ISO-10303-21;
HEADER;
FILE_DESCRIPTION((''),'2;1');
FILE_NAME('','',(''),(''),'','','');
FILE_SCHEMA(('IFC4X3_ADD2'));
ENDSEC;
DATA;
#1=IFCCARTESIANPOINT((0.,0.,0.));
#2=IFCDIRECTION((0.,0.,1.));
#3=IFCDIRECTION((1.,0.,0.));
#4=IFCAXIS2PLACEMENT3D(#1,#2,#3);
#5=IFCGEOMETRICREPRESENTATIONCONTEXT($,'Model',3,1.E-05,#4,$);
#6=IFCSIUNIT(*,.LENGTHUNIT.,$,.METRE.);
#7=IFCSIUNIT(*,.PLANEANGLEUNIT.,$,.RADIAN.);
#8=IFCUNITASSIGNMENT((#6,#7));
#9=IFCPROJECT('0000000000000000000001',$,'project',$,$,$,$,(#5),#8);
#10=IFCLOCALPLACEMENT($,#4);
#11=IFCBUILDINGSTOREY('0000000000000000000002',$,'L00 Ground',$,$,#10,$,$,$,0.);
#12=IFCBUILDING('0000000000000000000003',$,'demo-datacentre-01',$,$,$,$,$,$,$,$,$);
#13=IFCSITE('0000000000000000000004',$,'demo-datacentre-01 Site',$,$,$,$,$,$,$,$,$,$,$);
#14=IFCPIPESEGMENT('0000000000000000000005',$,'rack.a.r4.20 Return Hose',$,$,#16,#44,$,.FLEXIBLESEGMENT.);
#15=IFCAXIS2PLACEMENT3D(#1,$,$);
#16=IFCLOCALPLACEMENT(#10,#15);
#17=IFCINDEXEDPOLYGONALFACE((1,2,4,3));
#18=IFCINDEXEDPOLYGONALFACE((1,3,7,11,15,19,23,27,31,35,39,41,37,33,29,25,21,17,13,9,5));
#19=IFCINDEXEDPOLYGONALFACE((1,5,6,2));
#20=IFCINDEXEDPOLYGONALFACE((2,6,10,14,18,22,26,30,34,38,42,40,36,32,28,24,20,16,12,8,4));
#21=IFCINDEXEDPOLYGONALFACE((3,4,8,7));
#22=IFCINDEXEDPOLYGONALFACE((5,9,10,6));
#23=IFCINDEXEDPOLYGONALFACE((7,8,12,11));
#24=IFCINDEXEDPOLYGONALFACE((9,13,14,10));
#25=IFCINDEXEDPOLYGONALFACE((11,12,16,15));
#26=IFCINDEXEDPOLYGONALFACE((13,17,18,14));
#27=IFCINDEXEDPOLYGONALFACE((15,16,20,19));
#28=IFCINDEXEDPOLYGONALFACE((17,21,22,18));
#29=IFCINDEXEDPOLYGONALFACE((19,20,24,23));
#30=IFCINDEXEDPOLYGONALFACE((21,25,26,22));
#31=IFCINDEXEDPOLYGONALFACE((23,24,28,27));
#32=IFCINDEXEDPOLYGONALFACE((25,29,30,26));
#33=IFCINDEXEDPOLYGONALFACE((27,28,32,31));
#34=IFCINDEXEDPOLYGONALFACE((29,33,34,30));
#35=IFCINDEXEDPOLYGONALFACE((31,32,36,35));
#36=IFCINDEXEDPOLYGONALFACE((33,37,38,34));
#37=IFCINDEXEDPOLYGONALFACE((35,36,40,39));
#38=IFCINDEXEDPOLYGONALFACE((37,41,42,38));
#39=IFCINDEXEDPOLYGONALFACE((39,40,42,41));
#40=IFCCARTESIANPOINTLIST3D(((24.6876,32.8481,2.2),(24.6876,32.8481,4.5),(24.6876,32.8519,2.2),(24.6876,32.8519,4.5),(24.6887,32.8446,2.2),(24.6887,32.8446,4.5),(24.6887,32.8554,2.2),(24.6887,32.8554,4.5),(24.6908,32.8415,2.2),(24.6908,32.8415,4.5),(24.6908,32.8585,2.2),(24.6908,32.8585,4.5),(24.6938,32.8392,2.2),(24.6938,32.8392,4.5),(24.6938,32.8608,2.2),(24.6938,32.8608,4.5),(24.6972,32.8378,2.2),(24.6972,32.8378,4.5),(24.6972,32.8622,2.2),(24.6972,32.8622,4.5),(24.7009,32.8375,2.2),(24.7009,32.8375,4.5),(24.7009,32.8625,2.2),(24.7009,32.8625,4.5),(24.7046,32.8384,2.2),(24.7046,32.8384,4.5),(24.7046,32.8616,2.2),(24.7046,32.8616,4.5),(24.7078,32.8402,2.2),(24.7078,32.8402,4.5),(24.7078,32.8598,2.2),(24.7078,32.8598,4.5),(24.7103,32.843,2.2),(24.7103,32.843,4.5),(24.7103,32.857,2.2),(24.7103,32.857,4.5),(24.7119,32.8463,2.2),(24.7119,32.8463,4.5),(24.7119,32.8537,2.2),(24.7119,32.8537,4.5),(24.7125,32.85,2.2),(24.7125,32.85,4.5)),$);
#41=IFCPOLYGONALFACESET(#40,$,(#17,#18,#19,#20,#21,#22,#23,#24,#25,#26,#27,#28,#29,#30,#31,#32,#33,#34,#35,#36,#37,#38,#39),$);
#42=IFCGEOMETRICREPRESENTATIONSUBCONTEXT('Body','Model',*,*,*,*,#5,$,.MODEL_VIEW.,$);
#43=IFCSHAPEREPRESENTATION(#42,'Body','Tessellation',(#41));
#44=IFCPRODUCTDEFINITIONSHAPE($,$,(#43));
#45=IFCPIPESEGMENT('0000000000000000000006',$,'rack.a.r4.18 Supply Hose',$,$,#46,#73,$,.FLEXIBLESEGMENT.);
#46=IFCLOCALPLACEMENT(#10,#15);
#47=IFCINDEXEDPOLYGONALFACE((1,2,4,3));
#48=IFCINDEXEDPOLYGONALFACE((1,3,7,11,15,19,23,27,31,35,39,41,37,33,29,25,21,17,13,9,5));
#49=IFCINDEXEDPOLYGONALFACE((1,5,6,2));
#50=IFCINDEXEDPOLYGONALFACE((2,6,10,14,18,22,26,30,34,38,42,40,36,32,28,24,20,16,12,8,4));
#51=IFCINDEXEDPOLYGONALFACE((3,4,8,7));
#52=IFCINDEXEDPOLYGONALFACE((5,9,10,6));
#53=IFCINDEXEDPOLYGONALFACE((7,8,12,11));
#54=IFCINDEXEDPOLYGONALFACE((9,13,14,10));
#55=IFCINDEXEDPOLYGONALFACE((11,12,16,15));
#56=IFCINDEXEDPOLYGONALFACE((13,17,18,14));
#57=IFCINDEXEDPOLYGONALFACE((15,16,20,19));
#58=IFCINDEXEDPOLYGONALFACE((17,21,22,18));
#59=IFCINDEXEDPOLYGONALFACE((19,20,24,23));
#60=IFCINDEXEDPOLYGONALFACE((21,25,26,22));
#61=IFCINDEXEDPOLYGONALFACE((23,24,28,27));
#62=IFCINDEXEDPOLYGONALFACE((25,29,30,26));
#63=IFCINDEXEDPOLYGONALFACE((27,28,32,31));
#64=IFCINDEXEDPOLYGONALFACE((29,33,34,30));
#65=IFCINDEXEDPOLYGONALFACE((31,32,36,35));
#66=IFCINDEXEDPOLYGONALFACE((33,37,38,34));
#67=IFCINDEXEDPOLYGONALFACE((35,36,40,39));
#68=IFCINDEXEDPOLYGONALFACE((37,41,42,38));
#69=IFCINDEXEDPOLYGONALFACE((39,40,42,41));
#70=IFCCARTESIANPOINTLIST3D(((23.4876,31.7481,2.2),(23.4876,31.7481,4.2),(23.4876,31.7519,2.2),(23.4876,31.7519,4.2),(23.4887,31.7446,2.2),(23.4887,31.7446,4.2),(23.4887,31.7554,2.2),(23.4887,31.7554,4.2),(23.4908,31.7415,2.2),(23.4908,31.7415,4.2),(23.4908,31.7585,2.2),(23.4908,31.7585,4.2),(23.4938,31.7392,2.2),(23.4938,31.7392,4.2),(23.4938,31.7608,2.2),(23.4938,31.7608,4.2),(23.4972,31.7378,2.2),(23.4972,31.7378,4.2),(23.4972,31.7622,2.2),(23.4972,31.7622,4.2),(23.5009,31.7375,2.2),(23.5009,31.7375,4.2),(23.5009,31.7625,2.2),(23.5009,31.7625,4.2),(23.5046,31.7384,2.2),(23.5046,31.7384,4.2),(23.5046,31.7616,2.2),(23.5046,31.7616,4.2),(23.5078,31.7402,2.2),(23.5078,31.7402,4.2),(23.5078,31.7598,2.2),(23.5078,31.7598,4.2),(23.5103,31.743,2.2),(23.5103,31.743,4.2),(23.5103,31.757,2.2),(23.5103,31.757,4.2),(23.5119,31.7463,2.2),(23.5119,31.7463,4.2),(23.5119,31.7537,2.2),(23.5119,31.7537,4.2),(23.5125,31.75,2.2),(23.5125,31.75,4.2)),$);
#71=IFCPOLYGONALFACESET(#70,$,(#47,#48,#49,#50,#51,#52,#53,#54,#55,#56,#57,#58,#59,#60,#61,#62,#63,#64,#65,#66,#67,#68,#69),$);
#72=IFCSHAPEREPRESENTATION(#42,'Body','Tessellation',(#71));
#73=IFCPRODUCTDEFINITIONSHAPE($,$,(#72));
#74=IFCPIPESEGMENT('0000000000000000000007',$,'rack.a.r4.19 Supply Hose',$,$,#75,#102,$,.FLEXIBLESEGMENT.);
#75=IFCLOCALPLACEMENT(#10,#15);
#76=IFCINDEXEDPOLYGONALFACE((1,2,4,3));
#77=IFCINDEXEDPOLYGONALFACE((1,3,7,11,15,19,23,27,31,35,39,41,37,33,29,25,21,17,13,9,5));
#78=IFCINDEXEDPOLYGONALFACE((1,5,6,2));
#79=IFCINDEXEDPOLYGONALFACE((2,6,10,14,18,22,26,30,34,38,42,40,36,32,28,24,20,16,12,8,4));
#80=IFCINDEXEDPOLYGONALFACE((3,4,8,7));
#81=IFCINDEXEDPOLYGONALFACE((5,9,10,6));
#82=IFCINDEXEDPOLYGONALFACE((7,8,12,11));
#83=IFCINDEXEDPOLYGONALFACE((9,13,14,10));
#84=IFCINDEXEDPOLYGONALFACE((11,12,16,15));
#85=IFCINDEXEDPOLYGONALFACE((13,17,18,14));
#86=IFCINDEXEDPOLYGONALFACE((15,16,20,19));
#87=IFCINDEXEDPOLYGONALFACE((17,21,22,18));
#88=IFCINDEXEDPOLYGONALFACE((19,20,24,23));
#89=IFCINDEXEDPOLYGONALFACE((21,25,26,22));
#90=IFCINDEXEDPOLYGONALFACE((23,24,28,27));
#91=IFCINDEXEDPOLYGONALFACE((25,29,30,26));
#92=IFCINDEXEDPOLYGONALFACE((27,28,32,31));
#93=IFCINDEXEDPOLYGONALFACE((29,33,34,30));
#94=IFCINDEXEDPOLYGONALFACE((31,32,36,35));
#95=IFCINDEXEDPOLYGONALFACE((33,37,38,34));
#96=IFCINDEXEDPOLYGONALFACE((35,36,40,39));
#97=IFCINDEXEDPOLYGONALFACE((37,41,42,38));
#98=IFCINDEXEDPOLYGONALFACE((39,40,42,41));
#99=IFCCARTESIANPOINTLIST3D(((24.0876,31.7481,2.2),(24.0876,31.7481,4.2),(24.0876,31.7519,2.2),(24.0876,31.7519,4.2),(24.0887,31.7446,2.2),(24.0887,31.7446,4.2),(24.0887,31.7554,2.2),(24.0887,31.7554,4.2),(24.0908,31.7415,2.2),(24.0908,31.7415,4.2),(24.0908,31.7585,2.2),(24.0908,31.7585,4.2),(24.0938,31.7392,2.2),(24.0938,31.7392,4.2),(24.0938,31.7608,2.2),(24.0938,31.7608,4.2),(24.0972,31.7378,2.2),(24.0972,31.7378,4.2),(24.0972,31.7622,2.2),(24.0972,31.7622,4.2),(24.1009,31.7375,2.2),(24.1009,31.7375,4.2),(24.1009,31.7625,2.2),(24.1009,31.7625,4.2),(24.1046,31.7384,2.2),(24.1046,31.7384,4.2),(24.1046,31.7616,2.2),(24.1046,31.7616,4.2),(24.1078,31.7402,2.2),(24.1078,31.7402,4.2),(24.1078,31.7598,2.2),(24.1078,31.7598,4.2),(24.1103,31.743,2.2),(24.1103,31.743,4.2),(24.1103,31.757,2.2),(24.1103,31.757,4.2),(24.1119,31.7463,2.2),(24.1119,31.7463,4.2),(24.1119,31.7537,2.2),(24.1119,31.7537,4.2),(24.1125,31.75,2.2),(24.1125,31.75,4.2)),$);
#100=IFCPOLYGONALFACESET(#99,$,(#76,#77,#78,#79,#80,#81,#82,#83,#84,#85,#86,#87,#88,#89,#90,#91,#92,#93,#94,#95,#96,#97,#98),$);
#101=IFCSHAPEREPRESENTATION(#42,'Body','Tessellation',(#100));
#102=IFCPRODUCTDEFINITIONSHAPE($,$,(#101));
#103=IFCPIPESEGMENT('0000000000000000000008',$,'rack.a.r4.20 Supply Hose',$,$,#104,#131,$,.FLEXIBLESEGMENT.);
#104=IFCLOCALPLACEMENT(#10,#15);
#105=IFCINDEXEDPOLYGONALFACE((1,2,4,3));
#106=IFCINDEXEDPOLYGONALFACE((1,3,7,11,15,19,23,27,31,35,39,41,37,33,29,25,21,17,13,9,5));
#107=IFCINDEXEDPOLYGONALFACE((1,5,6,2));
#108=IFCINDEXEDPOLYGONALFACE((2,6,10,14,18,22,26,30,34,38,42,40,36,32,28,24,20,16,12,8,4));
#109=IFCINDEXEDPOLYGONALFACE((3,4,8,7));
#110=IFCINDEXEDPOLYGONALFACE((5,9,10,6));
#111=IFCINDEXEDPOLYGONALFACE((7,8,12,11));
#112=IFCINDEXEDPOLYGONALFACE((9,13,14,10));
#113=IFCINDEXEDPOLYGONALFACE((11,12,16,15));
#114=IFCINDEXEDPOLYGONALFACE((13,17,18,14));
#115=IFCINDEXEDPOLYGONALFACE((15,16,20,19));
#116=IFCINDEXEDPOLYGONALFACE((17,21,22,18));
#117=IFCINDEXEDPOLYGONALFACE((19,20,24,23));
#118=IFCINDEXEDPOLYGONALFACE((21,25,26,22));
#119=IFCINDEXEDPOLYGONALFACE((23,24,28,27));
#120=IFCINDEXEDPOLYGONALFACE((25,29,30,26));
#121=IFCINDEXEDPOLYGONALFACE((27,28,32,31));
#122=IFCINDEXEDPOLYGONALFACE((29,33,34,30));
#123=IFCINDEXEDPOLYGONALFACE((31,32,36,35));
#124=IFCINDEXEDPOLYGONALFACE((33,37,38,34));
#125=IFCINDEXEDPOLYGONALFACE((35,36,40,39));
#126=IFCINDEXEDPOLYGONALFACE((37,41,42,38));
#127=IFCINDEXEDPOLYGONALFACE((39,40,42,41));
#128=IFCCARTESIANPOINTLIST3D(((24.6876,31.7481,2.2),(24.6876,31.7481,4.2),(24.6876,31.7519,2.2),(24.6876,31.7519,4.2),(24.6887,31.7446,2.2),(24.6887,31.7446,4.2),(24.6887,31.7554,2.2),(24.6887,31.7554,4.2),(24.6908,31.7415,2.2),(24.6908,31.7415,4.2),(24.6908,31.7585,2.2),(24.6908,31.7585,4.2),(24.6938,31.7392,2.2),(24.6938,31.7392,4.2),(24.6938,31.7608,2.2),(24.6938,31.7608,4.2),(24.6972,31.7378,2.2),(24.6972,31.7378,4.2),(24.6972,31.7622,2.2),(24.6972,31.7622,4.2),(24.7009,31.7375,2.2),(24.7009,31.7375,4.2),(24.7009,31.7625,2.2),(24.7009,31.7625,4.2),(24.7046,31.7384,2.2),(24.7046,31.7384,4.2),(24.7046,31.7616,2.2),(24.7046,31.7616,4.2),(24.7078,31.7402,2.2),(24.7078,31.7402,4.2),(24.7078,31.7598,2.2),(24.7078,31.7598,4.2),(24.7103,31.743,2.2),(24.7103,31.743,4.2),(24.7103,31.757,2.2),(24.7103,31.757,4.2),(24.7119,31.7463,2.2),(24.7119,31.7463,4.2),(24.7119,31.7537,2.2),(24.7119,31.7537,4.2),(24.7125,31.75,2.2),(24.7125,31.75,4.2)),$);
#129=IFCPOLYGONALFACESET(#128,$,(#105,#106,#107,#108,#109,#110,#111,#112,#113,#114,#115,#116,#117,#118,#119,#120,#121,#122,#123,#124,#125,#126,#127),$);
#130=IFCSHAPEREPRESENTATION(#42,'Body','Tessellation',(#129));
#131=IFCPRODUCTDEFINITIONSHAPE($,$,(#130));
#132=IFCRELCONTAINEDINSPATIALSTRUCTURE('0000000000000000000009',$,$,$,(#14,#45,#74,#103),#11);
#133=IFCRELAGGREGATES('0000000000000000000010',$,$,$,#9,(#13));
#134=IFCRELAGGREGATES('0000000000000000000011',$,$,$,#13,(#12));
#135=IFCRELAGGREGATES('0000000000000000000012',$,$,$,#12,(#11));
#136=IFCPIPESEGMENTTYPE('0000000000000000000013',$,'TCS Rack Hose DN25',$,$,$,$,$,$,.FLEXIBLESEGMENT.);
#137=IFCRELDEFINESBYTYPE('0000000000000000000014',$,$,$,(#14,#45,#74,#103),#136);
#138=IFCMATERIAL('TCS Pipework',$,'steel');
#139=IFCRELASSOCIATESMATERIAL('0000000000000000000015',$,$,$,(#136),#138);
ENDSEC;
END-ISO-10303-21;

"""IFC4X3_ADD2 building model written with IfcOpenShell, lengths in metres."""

from ifc_helpers import new_model, si_unit, frame, origin_with_axes, place, context, subcontext, project, spatial, circle, extrude, material, type_object, element, save


model = new_model("IFC4X3_ADD2")

# Units and contexts
model_context = context("Model", 3, precision=1e-05, world=origin_with_axes())
body_context = subcontext(model_context, "Body", "Model", "MODEL_VIEW")
ifc_project = project(units=[si_unit("LENGTHUNIT", "METRE"), si_unit("PLANEANGLEUNIT", "RADIAN")], contexts=[model_context])

# Site, building, storey
site = spatial("IfcSite", under=ifc_project, Name="demo-datacentre-01 Site")
building = spatial("IfcBuilding", under=site, Name="demo-datacentre-01")
storey_placement = place(None, origin_with_axes())
storey = spatial("IfcBuildingStorey", under=building, at=storey_placement, Name="L00 Ground", Elevation=0.0)

# Shared definitions
ifc_material = material(Name="TCS Pipework", Category="steel")

# Pipe segments
pipe_segment_type_1 = type_object("IfcPipeSegmentType", Name="TCS Rack Hose DN25", PredefinedType="FLEXIBLESEGMENT", material=ifc_material)
for number, where, z_axis, x_axis, name in (
    (1, (24.7, 32.85, 4.5), (0.0, 0.0, -1.0), (1.0, 0.0, 0.0), "rack.a.r4.20 Return Hose"),
):
    element("IfcPipeSegment", number, at=place(storey_placement, frame(where, z_axis=z_axis, x_axis=x_axis)), inside=storey, type_object=pipe_segment_type_1, Name=name, PredefinedType="FLEXIBLESEGMENT", context=body_context, shape_type="SweptSolid", body=[
        extrude(circle(Radius=0.0125), origin_with_axes(), (0.0, 0.0, 1.0), 2.3),
    ])
for number, where, z_axis, x_axis, name in (
    (2, (23.5, 31.75, 4.2), (0.0, 0.0, -1.0), (1.0, 0.0, 0.0), "rack.a.r4.18 Supply Hose"),
    (3, (24.1, 31.75, 4.2), (0.0, 0.0, -1.0), (1.0, 0.0, 0.0), "rack.a.r4.19 Supply Hose"),
    (4, (24.7, 31.75, 4.2), (0.0, 0.0, -1.0), (1.0, 0.0, 0.0), "rack.a.r4.20 Supply Hose"),
):
    element("IfcPipeSegment", number, at=place(storey_placement, frame(where, z_axis=z_axis, x_axis=x_axis)), inside=storey, type_object=pipe_segment_type_1, Name=name, PredefinedType="FLEXIBLESEGMENT", context=body_context, shape_type="SweptSolid", body=[
        extrude(circle(Radius=0.0125), origin_with_axes(), (0.0, 0.0, 1.0), 2.0),
    ])

save(model, "model.ifc")
